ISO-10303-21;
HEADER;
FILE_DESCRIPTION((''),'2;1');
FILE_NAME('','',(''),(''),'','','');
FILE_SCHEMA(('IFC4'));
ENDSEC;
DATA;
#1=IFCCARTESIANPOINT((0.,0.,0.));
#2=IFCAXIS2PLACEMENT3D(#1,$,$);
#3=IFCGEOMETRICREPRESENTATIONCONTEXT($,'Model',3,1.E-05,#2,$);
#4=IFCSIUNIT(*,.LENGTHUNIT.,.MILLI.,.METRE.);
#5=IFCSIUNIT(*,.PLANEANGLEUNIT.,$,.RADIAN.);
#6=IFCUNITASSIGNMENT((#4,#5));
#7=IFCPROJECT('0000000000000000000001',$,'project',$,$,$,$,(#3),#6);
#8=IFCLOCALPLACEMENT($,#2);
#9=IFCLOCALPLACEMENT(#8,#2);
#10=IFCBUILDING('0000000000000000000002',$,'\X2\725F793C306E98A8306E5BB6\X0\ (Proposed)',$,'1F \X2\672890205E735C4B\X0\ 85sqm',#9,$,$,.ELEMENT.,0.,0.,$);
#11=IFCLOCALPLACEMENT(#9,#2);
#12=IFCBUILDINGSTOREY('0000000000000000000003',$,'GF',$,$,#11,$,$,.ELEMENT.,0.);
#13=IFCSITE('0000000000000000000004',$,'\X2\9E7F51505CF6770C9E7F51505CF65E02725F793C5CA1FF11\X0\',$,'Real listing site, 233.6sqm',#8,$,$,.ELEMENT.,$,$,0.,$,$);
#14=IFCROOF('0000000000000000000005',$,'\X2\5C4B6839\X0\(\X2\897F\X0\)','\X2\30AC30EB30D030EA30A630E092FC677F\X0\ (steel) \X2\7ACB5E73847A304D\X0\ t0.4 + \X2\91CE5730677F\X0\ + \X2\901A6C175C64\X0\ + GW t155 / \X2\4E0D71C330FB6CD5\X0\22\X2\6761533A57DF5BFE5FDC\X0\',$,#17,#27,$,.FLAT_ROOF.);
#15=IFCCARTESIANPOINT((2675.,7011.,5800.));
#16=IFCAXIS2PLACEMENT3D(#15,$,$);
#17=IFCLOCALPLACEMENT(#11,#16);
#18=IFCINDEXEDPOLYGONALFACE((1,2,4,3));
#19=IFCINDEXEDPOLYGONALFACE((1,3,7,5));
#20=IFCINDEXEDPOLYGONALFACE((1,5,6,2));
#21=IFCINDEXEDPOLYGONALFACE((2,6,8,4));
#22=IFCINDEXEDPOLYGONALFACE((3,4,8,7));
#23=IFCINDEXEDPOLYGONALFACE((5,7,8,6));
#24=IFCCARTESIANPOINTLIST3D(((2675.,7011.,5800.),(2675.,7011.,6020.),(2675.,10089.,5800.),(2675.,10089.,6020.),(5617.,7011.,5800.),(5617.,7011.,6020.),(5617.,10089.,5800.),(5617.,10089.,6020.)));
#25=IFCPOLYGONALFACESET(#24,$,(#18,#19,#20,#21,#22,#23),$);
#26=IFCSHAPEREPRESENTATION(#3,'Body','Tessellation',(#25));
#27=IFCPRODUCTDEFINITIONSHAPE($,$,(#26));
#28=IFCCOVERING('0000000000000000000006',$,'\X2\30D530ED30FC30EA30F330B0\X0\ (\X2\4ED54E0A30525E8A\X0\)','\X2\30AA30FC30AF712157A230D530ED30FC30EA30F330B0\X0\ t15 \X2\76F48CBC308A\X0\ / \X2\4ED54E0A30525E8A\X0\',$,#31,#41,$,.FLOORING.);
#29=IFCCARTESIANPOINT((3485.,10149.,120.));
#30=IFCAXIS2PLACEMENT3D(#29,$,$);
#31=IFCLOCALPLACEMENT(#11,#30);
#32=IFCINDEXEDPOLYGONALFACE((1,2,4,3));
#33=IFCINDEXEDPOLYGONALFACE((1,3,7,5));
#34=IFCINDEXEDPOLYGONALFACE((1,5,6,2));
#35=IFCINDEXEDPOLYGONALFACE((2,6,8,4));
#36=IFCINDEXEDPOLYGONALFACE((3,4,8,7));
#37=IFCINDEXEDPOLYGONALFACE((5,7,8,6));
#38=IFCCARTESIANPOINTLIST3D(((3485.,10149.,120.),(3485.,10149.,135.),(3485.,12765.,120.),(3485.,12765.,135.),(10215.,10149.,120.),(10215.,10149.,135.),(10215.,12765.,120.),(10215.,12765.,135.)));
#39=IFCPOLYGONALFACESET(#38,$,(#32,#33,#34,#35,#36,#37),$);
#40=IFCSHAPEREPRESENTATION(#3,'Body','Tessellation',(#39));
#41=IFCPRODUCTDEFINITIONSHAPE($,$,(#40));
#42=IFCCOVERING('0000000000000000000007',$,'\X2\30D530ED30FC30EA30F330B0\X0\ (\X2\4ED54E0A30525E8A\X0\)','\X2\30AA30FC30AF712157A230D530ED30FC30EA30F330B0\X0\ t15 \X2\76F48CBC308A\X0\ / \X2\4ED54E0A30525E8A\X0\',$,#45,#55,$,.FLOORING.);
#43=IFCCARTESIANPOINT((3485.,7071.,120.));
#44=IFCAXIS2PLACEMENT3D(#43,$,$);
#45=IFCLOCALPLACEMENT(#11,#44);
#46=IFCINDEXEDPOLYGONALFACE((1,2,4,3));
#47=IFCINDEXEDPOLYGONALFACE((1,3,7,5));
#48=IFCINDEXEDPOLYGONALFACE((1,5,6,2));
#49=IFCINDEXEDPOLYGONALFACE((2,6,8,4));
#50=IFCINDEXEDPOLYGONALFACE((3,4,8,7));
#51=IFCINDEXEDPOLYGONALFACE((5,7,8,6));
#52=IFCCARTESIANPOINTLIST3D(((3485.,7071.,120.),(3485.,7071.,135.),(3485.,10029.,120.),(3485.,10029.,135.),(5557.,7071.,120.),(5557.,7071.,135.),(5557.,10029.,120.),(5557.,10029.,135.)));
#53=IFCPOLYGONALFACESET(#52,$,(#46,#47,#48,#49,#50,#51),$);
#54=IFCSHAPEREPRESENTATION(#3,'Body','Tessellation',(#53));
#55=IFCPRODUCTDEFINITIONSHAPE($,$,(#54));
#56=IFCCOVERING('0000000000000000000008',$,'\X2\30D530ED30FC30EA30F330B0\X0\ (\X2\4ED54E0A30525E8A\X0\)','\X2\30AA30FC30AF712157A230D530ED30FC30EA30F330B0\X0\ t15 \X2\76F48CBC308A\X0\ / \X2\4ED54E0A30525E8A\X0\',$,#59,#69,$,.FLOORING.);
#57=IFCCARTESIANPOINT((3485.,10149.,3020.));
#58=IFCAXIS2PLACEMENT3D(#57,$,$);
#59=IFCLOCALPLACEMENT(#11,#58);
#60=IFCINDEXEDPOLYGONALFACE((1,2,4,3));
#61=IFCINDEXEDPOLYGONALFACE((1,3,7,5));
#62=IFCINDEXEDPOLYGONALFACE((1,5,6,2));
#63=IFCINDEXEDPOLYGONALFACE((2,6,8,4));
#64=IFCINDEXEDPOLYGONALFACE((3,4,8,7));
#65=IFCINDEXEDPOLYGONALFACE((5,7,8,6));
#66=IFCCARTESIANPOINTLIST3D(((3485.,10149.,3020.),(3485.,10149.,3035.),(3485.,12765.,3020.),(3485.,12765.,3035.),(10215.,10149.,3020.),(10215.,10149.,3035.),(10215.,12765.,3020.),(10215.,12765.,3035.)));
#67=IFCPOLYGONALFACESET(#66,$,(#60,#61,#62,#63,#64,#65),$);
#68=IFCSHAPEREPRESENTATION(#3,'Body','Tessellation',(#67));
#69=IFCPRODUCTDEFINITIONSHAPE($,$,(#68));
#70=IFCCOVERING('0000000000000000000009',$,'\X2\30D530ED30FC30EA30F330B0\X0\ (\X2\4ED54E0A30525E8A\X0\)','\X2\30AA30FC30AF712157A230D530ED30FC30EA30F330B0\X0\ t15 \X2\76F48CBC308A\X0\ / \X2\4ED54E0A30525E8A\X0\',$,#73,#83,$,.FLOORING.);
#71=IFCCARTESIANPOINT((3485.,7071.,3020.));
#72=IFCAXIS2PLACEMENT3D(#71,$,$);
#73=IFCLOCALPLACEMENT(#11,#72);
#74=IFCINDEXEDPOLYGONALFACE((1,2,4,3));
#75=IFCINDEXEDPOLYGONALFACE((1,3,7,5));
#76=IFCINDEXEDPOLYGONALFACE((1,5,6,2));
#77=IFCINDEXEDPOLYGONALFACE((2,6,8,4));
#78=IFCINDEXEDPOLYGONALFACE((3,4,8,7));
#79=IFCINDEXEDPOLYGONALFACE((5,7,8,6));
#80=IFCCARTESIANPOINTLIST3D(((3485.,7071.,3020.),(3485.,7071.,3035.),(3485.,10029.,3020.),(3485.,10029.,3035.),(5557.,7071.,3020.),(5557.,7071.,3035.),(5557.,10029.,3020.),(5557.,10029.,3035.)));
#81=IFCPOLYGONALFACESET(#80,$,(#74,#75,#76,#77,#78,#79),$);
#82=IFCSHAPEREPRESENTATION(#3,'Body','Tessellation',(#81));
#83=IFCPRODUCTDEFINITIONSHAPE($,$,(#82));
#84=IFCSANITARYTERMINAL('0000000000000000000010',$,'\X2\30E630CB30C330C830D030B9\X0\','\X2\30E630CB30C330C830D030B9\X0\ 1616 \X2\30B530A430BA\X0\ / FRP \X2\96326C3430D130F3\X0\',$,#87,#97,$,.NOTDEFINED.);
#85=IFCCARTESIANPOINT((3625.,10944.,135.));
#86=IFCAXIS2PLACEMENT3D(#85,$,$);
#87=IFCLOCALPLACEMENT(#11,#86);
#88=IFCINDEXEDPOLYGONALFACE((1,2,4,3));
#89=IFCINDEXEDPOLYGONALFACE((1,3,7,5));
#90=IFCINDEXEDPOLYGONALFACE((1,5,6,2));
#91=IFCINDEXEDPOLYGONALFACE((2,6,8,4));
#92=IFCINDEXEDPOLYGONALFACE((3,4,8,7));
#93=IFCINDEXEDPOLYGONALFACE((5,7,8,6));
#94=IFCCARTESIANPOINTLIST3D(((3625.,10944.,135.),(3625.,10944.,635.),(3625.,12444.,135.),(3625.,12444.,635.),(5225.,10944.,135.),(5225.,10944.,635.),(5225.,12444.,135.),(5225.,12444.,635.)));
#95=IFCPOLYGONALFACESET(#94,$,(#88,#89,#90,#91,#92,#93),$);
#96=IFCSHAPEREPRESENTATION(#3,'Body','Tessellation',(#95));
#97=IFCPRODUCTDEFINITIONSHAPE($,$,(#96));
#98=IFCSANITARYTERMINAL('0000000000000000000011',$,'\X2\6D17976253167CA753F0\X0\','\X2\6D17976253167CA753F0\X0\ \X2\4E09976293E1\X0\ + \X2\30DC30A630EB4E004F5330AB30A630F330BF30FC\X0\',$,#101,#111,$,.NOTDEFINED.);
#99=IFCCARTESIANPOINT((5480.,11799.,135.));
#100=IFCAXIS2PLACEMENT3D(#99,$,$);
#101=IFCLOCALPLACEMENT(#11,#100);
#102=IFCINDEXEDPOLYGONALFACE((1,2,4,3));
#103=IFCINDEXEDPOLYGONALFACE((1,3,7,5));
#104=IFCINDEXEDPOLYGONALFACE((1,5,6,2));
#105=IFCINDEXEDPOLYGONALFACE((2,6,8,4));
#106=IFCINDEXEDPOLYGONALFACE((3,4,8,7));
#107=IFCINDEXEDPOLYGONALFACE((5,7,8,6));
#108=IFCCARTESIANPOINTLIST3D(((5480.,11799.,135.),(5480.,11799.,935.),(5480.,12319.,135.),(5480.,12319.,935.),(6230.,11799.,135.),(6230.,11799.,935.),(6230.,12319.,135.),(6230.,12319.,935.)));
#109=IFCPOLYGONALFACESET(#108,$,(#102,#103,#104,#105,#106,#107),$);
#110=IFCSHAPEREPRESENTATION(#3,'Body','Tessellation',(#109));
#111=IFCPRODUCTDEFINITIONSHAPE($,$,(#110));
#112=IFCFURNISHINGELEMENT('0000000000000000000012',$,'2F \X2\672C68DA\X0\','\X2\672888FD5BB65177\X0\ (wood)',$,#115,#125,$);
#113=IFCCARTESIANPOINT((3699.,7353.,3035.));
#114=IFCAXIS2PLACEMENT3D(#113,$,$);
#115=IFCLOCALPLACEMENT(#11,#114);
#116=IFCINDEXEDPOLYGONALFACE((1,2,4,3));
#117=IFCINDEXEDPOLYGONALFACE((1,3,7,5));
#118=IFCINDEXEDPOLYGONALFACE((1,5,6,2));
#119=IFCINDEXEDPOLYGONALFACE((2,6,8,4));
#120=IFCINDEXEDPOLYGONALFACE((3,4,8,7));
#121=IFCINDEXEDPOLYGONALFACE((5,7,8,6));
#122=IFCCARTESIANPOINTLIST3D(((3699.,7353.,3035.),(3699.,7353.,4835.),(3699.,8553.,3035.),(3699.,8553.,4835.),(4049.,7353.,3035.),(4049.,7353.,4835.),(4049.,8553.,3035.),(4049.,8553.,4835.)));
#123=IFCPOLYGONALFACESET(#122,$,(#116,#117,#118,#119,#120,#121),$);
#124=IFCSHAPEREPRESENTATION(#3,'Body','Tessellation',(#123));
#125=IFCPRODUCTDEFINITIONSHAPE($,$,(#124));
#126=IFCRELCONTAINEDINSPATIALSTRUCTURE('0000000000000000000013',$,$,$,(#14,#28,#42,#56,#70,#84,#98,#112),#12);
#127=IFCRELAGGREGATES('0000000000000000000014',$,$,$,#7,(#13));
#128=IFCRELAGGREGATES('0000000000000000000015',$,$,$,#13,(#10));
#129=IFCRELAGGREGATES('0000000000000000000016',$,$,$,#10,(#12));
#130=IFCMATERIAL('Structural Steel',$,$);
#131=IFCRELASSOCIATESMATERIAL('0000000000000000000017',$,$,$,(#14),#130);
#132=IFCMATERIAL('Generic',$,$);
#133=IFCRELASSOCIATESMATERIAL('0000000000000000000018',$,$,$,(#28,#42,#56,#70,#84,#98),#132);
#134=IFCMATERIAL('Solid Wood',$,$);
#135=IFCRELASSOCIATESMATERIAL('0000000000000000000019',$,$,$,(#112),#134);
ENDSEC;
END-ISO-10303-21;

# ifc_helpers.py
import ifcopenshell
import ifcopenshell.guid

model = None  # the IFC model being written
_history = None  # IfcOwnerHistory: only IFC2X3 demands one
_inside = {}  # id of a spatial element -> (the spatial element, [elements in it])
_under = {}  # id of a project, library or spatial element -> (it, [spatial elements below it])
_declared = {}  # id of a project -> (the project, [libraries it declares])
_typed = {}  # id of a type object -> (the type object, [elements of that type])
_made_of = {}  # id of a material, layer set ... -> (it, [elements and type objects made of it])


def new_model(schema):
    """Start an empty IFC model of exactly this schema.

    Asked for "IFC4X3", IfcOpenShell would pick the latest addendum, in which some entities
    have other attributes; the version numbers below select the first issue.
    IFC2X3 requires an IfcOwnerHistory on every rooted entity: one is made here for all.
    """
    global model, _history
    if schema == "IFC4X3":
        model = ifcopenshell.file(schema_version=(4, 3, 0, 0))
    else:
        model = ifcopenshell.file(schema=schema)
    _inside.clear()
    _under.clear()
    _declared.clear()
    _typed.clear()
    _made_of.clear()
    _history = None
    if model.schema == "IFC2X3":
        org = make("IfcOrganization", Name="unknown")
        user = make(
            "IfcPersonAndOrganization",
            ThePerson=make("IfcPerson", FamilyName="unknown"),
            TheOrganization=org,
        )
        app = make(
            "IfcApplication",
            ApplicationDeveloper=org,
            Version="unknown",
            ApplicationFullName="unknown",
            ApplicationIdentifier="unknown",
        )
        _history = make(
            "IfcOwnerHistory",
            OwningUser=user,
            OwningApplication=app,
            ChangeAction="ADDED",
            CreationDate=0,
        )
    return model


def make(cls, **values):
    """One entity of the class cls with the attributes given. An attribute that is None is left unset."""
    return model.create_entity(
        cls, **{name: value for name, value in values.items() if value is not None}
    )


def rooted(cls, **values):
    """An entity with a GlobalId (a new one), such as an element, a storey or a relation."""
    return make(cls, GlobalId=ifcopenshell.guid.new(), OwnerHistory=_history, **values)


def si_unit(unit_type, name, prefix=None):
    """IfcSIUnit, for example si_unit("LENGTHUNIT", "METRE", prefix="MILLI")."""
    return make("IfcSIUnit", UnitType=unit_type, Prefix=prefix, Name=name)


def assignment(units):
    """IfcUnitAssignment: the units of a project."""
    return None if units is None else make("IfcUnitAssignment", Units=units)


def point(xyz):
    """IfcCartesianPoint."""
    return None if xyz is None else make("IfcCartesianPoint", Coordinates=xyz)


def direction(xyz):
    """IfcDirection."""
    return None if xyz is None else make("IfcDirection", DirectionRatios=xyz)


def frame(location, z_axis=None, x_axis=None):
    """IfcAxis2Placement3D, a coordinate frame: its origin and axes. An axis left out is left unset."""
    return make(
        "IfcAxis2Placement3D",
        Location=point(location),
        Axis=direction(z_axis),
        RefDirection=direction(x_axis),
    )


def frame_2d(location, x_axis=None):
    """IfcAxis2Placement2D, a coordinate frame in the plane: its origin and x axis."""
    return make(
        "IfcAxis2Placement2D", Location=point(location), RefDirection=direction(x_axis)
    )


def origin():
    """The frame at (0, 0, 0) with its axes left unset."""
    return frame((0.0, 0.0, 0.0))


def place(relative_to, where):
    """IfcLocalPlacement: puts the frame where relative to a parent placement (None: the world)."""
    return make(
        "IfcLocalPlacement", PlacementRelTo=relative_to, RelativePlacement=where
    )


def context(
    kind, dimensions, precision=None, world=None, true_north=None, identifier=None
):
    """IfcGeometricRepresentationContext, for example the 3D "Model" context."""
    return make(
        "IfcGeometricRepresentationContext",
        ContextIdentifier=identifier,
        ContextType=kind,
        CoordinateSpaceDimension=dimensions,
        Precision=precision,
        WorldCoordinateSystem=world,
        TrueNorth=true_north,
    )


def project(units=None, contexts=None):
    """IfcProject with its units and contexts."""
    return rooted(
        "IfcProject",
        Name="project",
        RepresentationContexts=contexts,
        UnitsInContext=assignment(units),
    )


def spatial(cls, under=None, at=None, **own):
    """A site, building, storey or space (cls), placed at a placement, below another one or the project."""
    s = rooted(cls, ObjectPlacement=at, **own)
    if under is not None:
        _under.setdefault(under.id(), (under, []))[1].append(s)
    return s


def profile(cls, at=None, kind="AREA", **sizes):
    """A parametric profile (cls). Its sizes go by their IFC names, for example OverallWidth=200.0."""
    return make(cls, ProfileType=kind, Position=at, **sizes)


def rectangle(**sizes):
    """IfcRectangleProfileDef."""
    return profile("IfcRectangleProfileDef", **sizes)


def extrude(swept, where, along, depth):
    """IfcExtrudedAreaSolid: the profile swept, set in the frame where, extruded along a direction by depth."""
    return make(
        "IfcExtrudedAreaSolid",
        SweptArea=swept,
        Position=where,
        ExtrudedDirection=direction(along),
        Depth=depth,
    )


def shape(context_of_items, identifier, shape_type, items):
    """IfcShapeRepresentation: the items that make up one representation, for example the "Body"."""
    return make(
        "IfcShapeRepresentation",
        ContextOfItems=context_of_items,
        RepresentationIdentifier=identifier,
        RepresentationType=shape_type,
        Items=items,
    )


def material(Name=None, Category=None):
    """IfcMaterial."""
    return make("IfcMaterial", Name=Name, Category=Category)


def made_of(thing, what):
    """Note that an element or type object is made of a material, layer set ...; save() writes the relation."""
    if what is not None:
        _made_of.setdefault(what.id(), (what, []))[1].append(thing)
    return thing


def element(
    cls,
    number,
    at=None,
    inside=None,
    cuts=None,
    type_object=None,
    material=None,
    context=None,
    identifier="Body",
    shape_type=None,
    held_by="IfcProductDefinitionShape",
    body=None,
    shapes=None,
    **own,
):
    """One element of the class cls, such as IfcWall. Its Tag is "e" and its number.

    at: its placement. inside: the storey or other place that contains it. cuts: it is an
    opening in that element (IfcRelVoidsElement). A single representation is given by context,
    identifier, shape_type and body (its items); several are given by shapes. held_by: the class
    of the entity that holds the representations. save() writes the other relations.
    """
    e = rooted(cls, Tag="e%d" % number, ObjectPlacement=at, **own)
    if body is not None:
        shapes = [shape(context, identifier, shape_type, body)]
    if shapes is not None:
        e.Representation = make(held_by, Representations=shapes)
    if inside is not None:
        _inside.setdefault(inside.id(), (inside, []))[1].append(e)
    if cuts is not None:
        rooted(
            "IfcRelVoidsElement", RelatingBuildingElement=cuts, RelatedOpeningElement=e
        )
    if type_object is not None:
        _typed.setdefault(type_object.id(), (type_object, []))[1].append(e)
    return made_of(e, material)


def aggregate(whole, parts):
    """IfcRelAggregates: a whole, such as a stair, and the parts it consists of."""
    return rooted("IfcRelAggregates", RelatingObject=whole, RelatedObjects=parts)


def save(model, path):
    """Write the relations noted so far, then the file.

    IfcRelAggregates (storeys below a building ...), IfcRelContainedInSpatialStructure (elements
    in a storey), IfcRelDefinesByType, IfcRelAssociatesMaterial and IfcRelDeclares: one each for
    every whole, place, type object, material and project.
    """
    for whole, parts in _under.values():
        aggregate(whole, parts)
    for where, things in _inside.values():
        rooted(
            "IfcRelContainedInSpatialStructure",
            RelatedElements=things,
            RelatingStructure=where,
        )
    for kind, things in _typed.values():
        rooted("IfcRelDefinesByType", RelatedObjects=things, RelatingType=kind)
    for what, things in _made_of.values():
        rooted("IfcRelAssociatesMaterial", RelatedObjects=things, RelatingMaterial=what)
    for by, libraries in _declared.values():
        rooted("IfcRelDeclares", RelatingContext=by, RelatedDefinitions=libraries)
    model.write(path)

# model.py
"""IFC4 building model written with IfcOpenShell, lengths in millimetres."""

from ifc_helpers import new_model, si_unit, frame, frame_2d, origin, place, context, project, spatial, rectangle, extrude, material, element, save


model = new_model("IFC4")

# Units and contexts
model_context = context("Model", 3, precision=1e-05, world=origin())
ifc_project = project(units=[si_unit("LENGTHUNIT", "METRE", prefix="MILLI"), si_unit("PLANEANGLEUNIT", "RADIAN")], contexts=[model_context])

# Site, building, storey
site_placement = place(None, origin())
site = spatial("IfcSite", under=ifc_project, at=site_placement, Name="鹿児島県鹿児島市牟礼岡１", ObjectType="Real listing site, 233.6sqm", CompositionType="ELEMENT", RefElevation=0.0)
building_placement = place(site_placement, origin())
building = spatial("IfcBuilding", under=site, at=building_placement, Name="牟礼の風の家 (Proposed)", ObjectType="1F 木造平屋 85sqm", CompositionType="ELEMENT", ElevationOfRefHeight=0.0, ElevationOfTerrain=0.0)
storey_placement = place(building_placement, origin())
storey = spatial("IfcBuildingStorey", under=building, at=storey_placement, Name="GF", CompositionType="ELEMENT", Elevation=0.0)

# Shared definitions
ifc_material_1 = material(Name="Solid Wood")

# Roof
ifc_material_2 = material(Name="Structural Steel")
roof_placement = place(storey_placement, frame((2675.0, 7011.0, 5800.0)))
element("IfcRoof", 1, at=roof_placement, inside=storey, material=ifc_material_2, Name="屋根(西)", Description="ガルバリウム鋼板 (steel) 立平葺き t0.4 + 野地板 + 通気層 + GW t155 / 不燃・法22条区域対応", PredefinedType="FLAT_ROOF", context=model_context, shape_type="SweptSolid", body=[
    extrude(rectangle(XDim=2942.0, YDim=3078.0, at=frame_2d((1471.0, 1539.0))), frame((2675.0, 7011.0, 5800.0)), (0.0, 0.0, 1.0), 220.0),
])

# Coverings
ifc_material_3 = material(Name="Generic")
covering_1_placement = place(storey_placement, frame((3485.0, 10149.0, 120.0)))
element("IfcCovering", 2, at=covering_1_placement, inside=storey, material=ifc_material_3, Name="フローリング (仕上げ床)", Description="オーク無垢フローリング t15 直貼り / 仕上げ床", PredefinedType="FLOORING", context=model_context, shape_type="SweptSolid", body=[
    extrude(rectangle(XDim=6730.0, YDim=2616.0, at=frame_2d((3365.0, 1308.0))), frame((3485.0, 10149.0, 120.0)), (0.0, 0.0, 1.0), 15.0),
])
covering_2_placement = place(storey_placement, frame((3485.0, 7071.0, 120.0)))
element("IfcCovering", 3, at=covering_2_placement, inside=storey, material=ifc_material_3, Name="フローリング (仕上げ床)", Description="オーク無垢フローリング t15 直貼り / 仕上げ床", PredefinedType="FLOORING", context=model_context, shape_type="SweptSolid", body=[
    extrude(rectangle(XDim=2072.0, YDim=2958.0, at=frame_2d((1036.0, 1479.0))), frame((3485.0, 7071.0, 120.0)), (0.0, 0.0, 1.0), 15.0),
])
covering_3_placement = place(storey_placement, frame((3485.0, 10149.0, 3020.0)))
element("IfcCovering", 4, at=covering_3_placement, inside=storey, material=ifc_material_3, Name="フローリング (仕上げ床)", Description="オーク無垢フローリング t15 直貼り / 仕上げ床", PredefinedType="FLOORING", context=model_context, shape_type="SweptSolid", body=[
    extrude(rectangle(XDim=6730.0, YDim=2616.0, at=frame_2d((3365.0, 1308.0))), frame((3485.0, 10149.0, 3020.0)), (0.0, 0.0, 1.0), 15.0),
])
covering_4_placement = place(storey_placement, frame((3485.0, 7071.0, 3020.0)))
element("IfcCovering", 5, at=covering_4_placement, inside=storey, material=ifc_material_3, Name="フローリング (仕上げ床)", Description="オーク無垢フローリング t15 直貼り / 仕上げ床", PredefinedType="FLOORING", context=model_context, shape_type="SweptSolid", body=[
    extrude(rectangle(XDim=2072.0, YDim=2958.0, at=frame_2d((1036.0, 1479.0))), frame((3485.0, 7071.0, 3020.0)), (0.0, 0.0, 1.0), 15.0),
])

# Sanitary terminals
sanitary_terminal_1_placement = place(storey_placement, frame((3625.0, 10944.0, 135.0)))
element("IfcSanitaryTerminal", 6, at=sanitary_terminal_1_placement, inside=storey, material=ifc_material_3, Name="ユニットバス", Description="ユニットバス 1616 サイズ / FRP 防水パン", PredefinedType="NOTDEFINED", context=model_context, shape_type="SweptSolid", body=[
    extrude(rectangle(XDim=1600.0, YDim=1500.0, at=frame_2d((800.0, 750.0))), frame((3625.0, 10944.0, 135.0)), (0.0, 0.0, 1.0), 500.0),
])
sanitary_terminal_2_placement = place(storey_placement, frame((5480.0, 11799.0, 135.0)))
element("IfcSanitaryTerminal", 7, at=sanitary_terminal_2_placement, inside=storey, material=ifc_material_3, Name="洗面化粧台", Description="洗面化粧台 三面鏡 + ボウル一体カウンター", PredefinedType="NOTDEFINED", context=model_context, shape_type="SweptSolid", body=[
    extrude(rectangle(XDim=750.0, YDim=520.0, at=frame_2d((375.0, 260.0))), frame((5480.0, 11799.0, 135.0)), (0.0, 0.0, 1.0), 800.0),
])

# Furnishing element
furnishing_placement = place(storey_placement, frame((3699.0, 7353.0, 3035.0)))
element("IfcFurnishingElement", 8, at=furnishing_placement, inside=storey, material=ifc_material_1, Name="2F 本棚", Description="木製家具 (wood)", context=model_context, shape_type="SweptSolid", body=[
    extrude(rectangle(XDim=350.0, YDim=1200.0, at=frame_2d((175.0, 600.0))), frame((3699.0, 7353.0, 3035.0)), (0.0, 0.0, 1.0), 1800.0),
])

save(model, "model.ifc")
